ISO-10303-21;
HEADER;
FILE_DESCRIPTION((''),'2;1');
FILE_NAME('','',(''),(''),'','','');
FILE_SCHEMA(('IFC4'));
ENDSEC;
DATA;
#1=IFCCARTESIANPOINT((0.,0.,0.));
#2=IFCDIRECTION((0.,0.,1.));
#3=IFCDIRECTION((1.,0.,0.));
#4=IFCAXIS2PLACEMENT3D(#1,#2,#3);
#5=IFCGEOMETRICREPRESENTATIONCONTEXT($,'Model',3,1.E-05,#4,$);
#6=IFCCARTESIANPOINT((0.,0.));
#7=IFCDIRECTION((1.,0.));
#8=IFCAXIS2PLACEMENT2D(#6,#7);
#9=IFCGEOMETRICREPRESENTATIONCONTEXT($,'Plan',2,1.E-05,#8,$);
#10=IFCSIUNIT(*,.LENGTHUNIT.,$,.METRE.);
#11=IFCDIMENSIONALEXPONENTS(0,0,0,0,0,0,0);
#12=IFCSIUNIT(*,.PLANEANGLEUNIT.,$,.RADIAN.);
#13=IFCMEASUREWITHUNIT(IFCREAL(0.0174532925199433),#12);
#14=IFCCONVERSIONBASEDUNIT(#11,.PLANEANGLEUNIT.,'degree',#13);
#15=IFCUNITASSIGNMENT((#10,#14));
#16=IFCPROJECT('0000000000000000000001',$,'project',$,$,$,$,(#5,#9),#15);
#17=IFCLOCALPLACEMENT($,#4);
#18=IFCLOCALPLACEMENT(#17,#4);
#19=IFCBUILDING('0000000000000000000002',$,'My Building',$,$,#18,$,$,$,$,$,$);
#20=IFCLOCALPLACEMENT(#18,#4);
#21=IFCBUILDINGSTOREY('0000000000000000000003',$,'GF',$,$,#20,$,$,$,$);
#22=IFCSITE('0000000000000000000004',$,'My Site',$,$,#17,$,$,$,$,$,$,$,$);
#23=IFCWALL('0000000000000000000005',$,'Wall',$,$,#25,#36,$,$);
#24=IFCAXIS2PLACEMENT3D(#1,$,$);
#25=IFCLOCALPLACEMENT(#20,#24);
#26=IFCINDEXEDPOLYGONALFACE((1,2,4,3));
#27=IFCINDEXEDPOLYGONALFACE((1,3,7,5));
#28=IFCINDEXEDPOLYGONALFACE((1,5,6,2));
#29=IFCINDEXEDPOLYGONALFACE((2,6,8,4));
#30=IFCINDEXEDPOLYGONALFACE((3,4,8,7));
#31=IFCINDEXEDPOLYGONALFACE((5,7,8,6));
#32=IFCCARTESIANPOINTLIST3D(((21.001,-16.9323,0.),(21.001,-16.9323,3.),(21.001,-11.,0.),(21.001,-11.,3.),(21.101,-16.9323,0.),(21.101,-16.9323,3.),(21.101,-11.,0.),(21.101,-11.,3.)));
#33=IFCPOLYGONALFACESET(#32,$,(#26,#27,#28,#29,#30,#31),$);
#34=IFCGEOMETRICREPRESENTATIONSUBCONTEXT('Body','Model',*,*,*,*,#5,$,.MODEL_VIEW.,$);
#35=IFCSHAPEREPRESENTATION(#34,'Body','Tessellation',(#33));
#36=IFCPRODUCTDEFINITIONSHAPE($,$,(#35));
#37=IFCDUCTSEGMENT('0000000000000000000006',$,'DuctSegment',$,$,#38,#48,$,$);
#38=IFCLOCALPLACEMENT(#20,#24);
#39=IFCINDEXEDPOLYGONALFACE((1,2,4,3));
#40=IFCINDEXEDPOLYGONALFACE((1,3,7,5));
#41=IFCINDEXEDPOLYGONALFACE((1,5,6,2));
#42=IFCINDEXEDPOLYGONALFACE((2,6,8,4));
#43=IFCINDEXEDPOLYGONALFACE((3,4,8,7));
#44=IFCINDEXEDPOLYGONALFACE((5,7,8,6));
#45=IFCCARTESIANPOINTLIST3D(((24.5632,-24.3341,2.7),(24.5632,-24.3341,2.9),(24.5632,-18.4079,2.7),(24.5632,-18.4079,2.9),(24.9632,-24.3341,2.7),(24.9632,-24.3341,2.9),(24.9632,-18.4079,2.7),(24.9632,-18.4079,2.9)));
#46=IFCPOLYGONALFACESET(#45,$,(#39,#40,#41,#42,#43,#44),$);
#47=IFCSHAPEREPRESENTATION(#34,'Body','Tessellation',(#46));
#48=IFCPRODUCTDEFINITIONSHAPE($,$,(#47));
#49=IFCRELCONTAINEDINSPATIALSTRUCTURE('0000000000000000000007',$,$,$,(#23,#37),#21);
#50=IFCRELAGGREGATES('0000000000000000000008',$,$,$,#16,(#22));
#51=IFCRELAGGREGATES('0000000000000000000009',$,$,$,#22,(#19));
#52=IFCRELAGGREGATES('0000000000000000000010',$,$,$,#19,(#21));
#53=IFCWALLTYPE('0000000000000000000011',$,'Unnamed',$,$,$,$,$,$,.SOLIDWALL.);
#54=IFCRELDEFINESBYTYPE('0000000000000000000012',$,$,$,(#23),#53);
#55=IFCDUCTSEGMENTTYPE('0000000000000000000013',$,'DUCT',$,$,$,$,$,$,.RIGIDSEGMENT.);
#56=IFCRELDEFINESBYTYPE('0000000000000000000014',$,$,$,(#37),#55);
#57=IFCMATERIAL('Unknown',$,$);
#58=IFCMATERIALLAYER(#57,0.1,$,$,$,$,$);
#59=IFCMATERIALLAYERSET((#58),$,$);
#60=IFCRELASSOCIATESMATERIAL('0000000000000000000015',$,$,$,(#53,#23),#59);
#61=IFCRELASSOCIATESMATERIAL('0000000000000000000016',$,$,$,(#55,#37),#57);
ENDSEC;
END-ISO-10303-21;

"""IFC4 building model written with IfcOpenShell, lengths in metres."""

from ifc_helpers import new_model, entity, si_unit, converted_unit, frame, origin_with_axes, origin_2d_with_axis, place, context, subcontext, project, spatial, line, indexed_curve, rectangle, outline, extrude, material, layer, layer_set, layer_usage, material_profile, profile_set, profile_usage, type_object, element, save


model = new_model("IFC4")

# Units and contexts
model_context = context("Model", 3, precision=1e-05, world=origin_with_axes())
plan_context = context("Plan", 2, precision=1e-05, world=origin_2d_with_axis())
body_context_1 = subcontext(model_context, "Body", "Model", "MODEL_VIEW")
ifc_project = project(units=[si_unit("LENGTHUNIT", "METRE"), converted_unit("PLANEANGLEUNIT", "degree", entity("IfcReal", 0.0174532925199433), si_unit("PLANEANGLEUNIT", "RADIAN"), dimensions=[0, 0, 0, 0, 0, 0, 0])], contexts=[model_context, plan_context])

# Site, building, storey
site_placement = place(None, origin_with_axes())
site = spatial("IfcSite", under=ifc_project, at=site_placement, Name="My Site")
building_placement = place(site_placement, origin_with_axes())
building = spatial("IfcBuilding", under=site, at=building_placement, Name="My Building")
storey_placement = place(building_placement, origin_with_axes())
storey = spatial("IfcBuildingStorey", under=building, at=storey_placement, Name="GF")

# Shared definitions
ifc_material = material(Name="Unknown")
ifc_layer = layer(ifc_material, 0.1)
ifc_layer_set = layer_set([ifc_layer])
wall_type = type_object("IfcWallType", Name="Unnamed", PredefinedType="SOLIDWALL", material=ifc_layer_set)

# Wall
ifc_layer_usage_1 = layer_usage(ifc_layer_set, "AXIS2", "POSITIVE", 0.0)
wall_1_placement = place(storey_placement, frame((21.101, -16.9323, 0.0), z_axis=(0.0, 0.0, 1.0), x_axis=(0.0, 1.0, 0.0)))
element("IfcWall", 1, at=wall_1_placement, inside=storey, type_object=wall_type, material=ifc_layer_usage_1, Name="Wall", context=body_context_1, shape_type="SweptSolid", body=[
    extrude(outline(indexed_curve([(0.0, 0.0), (0.0, 0.1), (5.9323, 0.1), (5.9323, 0.0)], segments=[line(1, 2, 3, 4, 1)])), origin_with_axes(), (0.0, 0.0, 1.0), 3.0),
])

# Duct segment
ifc_material_profile = material_profile(ifc_material, rectangle(XDim=0.4, YDim=0.2))
ifc_profile_set = profile_set([ifc_material_profile])
ifc_profile_usage = profile_usage(ifc_profile_set, cardinal=5)
duct_segment_type = type_object("IfcDuctSegmentType", Name="DUCT", PredefinedType="RIGIDSEGMENT", material=ifc_profile_set)
duct_segment_placement = place(storey_placement, frame((24.7632, -18.4079, 2.8), z_axis=(0.0, -1.0, 0.0), x_axis=(1.0, 0.0, 0.0)))
element("IfcDuctSegment", 2, at=duct_segment_placement, inside=storey, type_object=duct_segment_type, material=ifc_profile_usage, Name="DuctSegment", context=body_context_1, shape_type="SweptSolid", body=[
    extrude(rectangle(XDim=0.4, YDim=0.2), origin_with_axes(), (0.0, 0.0, 1.0), 5.9262),
])

save(model, "model.ifc")
